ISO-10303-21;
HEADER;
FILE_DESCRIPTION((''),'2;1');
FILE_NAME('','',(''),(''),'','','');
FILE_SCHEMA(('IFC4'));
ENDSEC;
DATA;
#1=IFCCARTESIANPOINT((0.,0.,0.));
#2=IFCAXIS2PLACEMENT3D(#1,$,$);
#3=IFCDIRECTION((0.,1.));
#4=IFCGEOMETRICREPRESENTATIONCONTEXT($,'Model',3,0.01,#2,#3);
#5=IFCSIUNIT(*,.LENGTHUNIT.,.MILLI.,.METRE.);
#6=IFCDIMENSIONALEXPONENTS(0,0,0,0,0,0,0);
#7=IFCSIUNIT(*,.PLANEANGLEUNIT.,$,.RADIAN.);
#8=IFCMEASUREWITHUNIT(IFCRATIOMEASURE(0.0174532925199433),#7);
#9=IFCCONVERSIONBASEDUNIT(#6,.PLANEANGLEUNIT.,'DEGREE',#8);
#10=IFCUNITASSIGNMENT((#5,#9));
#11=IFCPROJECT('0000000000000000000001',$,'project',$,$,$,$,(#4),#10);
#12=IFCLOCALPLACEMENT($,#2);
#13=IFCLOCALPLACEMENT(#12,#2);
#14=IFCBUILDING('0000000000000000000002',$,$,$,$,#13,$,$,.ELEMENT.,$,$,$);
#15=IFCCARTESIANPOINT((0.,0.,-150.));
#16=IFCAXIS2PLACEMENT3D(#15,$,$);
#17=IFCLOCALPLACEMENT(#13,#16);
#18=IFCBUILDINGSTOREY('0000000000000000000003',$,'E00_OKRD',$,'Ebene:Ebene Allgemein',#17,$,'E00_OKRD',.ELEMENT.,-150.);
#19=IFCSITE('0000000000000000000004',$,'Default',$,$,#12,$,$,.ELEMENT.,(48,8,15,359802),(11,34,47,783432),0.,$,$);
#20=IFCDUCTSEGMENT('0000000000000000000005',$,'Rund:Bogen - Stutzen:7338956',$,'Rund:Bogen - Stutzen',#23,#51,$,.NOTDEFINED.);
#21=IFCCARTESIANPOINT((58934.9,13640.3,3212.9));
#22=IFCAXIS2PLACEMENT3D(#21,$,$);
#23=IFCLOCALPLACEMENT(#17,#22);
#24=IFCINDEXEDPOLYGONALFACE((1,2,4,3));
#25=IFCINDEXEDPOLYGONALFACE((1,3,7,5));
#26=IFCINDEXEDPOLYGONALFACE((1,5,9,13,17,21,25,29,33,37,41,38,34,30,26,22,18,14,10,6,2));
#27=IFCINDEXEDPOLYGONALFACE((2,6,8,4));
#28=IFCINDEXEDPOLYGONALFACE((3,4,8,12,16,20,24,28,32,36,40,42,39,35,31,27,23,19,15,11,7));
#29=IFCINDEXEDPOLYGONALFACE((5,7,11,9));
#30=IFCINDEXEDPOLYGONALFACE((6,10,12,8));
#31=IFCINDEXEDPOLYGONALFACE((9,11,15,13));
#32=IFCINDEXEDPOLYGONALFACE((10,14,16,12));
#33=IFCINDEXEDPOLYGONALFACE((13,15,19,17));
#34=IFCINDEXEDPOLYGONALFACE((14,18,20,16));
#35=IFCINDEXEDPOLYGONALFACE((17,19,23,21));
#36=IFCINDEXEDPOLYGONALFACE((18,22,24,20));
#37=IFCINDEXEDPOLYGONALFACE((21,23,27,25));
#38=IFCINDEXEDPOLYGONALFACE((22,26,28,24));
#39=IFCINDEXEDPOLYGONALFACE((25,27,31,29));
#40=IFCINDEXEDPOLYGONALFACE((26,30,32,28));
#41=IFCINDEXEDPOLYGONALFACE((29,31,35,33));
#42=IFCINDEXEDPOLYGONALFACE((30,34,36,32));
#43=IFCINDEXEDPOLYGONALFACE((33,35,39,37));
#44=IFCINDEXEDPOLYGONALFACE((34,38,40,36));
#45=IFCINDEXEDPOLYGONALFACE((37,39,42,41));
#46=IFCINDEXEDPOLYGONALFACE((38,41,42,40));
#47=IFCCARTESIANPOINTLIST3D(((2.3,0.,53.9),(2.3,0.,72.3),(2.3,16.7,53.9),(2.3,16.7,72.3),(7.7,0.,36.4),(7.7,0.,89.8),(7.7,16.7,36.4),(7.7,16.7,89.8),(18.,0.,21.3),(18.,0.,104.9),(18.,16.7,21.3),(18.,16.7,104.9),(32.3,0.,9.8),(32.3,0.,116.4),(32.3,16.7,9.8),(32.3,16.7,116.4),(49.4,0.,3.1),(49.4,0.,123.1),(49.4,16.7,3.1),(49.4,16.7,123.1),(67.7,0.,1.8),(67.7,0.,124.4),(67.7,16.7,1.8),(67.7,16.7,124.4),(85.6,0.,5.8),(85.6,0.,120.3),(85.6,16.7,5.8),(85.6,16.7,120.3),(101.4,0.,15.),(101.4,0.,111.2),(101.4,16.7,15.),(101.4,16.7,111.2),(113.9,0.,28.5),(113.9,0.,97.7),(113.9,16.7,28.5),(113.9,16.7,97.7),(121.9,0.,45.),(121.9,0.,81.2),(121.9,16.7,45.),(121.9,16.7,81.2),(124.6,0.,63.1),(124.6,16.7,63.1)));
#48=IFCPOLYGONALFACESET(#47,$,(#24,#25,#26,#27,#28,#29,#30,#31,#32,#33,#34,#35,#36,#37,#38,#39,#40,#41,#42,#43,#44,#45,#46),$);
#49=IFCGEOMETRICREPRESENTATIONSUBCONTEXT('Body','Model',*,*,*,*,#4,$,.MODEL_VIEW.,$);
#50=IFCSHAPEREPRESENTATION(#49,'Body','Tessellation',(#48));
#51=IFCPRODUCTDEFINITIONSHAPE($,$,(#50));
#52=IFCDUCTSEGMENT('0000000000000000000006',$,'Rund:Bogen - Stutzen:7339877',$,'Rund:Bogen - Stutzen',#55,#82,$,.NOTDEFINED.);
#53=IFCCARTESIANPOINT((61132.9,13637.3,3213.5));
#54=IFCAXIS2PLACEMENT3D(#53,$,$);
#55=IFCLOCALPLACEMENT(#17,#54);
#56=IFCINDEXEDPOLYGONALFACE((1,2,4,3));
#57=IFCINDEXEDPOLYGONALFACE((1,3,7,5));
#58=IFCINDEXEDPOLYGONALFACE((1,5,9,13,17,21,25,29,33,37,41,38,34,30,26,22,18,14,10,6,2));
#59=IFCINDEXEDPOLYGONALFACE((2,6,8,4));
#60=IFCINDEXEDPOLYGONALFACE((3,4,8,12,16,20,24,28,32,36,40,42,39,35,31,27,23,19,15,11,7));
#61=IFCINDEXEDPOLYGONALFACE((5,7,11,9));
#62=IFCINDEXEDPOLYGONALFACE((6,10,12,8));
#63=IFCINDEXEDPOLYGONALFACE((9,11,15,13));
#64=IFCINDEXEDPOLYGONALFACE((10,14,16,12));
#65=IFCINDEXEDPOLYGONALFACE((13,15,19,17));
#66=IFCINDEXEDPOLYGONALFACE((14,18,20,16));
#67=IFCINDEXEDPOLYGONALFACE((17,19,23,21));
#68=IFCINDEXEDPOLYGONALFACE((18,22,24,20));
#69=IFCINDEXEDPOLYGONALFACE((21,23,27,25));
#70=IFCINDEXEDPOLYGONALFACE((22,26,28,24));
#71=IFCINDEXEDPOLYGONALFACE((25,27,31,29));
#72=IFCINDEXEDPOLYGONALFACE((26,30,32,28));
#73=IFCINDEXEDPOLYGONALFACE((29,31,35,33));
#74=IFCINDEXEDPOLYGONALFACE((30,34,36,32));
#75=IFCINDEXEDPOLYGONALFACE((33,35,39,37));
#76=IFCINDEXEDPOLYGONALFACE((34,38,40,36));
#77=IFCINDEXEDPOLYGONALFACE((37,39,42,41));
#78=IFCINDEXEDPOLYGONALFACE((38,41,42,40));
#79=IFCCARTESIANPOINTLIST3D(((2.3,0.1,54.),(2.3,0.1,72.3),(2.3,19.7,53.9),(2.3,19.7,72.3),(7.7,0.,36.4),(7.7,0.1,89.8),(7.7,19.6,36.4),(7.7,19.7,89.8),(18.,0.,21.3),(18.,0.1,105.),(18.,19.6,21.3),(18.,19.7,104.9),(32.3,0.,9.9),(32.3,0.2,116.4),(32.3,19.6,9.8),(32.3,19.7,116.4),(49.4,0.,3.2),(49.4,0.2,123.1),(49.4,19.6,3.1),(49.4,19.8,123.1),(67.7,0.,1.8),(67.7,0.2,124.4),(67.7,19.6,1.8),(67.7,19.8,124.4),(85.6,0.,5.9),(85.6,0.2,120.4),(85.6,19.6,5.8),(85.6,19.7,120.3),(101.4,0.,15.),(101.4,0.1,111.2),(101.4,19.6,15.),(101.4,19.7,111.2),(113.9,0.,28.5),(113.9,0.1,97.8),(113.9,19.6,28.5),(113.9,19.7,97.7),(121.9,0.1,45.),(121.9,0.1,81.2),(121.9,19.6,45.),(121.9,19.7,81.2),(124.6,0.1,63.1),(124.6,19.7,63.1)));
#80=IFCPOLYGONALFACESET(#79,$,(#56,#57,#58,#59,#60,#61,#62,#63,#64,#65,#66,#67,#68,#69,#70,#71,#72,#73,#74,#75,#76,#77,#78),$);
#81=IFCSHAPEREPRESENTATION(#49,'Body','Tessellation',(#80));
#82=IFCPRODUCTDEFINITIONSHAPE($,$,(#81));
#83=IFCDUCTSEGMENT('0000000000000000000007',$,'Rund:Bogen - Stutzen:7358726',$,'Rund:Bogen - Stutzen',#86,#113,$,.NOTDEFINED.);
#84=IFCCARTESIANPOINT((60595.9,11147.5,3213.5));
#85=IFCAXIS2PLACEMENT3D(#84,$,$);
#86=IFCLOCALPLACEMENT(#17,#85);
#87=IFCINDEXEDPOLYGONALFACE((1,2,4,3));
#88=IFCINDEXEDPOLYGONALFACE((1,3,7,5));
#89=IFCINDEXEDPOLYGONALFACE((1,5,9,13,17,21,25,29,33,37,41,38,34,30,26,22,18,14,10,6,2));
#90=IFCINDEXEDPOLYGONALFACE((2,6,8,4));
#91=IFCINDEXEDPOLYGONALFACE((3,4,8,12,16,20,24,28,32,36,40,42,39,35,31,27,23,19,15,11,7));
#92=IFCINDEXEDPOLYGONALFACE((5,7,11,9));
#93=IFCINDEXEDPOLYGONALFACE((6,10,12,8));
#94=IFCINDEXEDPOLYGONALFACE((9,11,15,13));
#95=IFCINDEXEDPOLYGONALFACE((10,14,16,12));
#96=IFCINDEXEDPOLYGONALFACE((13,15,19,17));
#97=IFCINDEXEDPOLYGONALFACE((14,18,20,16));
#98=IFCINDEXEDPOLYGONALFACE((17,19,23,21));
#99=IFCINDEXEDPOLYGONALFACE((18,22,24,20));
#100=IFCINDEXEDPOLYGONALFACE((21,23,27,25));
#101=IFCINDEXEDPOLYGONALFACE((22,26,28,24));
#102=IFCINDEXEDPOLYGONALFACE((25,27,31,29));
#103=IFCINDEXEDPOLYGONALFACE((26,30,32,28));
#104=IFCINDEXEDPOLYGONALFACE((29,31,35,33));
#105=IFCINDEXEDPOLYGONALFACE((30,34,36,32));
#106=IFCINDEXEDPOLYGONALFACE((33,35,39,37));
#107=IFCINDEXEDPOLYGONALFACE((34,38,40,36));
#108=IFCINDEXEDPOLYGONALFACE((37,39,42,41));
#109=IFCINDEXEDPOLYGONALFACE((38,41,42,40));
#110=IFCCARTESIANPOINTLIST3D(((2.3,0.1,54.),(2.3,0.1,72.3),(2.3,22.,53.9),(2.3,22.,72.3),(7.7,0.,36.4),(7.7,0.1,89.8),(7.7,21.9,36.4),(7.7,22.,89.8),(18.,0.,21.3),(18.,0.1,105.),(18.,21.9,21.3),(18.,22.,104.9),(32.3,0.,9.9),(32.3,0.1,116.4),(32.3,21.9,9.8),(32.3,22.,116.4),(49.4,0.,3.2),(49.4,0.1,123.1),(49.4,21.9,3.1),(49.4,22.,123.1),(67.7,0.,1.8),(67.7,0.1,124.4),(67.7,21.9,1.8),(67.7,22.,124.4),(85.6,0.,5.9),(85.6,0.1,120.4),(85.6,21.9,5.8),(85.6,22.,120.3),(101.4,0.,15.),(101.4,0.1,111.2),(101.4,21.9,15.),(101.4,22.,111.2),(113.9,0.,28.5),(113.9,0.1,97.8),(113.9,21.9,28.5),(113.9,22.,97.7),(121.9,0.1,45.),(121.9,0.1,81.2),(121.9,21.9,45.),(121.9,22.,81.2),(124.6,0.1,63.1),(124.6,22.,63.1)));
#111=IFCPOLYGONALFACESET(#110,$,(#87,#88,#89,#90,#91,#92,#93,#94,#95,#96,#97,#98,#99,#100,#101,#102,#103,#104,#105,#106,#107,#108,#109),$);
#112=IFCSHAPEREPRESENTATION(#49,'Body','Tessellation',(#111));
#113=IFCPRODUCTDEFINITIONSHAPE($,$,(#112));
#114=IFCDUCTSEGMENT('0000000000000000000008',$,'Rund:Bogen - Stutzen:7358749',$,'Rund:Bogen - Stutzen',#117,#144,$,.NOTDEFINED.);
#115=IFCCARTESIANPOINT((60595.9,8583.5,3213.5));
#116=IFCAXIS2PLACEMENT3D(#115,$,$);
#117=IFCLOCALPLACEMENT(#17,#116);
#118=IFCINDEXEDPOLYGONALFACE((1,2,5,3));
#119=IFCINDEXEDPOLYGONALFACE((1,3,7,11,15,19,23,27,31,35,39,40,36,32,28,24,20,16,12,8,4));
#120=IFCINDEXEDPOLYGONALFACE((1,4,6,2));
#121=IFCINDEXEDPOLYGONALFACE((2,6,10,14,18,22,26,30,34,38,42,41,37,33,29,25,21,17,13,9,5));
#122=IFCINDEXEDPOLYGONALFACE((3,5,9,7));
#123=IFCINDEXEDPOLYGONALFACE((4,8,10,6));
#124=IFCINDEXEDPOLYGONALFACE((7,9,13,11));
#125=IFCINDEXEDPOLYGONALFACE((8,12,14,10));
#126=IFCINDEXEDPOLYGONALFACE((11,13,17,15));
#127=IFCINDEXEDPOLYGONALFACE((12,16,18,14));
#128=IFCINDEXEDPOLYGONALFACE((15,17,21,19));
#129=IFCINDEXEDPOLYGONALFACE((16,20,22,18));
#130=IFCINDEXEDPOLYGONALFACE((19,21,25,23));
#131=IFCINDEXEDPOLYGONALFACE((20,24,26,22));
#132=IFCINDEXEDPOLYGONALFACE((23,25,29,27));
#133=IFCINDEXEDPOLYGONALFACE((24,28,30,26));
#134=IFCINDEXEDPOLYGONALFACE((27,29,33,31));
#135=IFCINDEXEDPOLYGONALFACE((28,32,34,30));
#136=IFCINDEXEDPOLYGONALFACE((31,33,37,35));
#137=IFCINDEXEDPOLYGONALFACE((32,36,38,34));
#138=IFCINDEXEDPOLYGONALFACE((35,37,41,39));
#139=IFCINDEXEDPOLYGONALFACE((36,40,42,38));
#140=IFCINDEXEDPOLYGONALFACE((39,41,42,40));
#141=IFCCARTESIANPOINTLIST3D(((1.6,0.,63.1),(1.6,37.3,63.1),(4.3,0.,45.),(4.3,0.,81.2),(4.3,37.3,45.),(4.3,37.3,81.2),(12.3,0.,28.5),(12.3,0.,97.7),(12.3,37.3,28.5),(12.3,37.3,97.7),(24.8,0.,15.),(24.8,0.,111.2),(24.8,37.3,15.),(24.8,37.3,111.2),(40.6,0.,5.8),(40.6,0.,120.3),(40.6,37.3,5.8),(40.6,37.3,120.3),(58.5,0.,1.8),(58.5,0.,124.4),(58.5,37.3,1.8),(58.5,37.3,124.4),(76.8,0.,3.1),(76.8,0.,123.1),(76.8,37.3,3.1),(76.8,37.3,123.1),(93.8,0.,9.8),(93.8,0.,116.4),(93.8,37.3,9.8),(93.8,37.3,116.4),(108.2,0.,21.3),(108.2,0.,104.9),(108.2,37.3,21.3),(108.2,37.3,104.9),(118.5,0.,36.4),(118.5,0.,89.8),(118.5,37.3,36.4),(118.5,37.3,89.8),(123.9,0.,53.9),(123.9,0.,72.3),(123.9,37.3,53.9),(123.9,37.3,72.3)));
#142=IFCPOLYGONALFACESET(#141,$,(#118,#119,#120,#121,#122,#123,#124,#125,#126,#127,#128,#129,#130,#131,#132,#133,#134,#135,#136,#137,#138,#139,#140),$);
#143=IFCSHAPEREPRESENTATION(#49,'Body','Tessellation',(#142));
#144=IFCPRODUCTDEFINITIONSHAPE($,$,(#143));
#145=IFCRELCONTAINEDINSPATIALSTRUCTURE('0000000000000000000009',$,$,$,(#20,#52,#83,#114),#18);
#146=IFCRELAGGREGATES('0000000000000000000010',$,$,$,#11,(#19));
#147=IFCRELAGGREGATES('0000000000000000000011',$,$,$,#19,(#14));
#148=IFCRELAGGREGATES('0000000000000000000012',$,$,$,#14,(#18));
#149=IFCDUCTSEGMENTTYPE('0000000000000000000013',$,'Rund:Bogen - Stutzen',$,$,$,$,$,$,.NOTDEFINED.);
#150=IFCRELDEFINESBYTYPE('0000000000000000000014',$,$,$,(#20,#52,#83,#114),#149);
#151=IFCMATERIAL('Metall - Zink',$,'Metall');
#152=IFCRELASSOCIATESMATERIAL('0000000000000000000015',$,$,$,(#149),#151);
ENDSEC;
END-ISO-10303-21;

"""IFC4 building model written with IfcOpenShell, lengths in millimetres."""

from ifc_helpers import new_model, entity, si_unit, converted_unit, direction, frame, frame_2d, origin, origin_2d_with_axis, place, context, subcontext, project, spatial, circle, extrude, material, type_object, element, save


model = new_model("IFC4")

# Units and contexts
model_context = context("Model", 3, precision=0.01, world=origin(), true_north=direction((0.0, 1.0)))
body_context = subcontext(model_context, "Body", "Model", "MODEL_VIEW")
ifc_project = project(units=[si_unit("LENGTHUNIT", "METRE", prefix="MILLI"), converted_unit("PLANEANGLEUNIT", "DEGREE", entity("IfcRatioMeasure", 0.0174532925199433), si_unit("PLANEANGLEUNIT", "RADIAN"), dimensions=[0, 0, 0, 0, 0, 0, 0])], contexts=[model_context])

# Site, building, storey
site_placement = place(None, origin())
site = spatial("IfcSite", under=ifc_project, at=site_placement, Name="Default", CompositionType="ELEMENT", RefLatitude=(48, 8, 15, 359802), RefLongitude=(11, 34, 47, 783432), RefElevation=0.0)
building_placement = place(site_placement, origin())
building = spatial("IfcBuilding", under=site, at=building_placement, CompositionType="ELEMENT")
storey_placement = place(building_placement, frame((0.0, 0.0, -150.0)))
storey = spatial("IfcBuildingStorey", under=building, at=storey_placement, Name="E00_OKRD", ObjectType="Ebene:Ebene Allgemein", LongName="E00_OKRD", CompositionType="ELEMENT", Elevation=-150.0)

# Shared definitions
ifc_material_1 = material(Name="Metall - Zink", Category="Metall")

# Duct segments
duct_segment_type_1 = type_object("IfcDuctSegmentType", Name="Rund:Bogen - Stutzen", PredefinedType="NOTDEFINED", material=ifc_material_1)
duct_segment_1_placement = place(storey_placement, frame((58934.9, 13640.3, 3212.9)))
element("IfcDuctSegment", 1, at=duct_segment_1_placement, inside=storey, type_object=duct_segment_type_1, Name="Rund:Bogen - Stutzen:7338956", ObjectType="Rund:Bogen - Stutzen", PredefinedType="NOTDEFINED", context=body_context, shape_type="SweptSolid", body=[
    extrude(circle(Radius=61.5, at=frame_2d((0.0, 0.0), x_axis=(1.0, 0.0))), frame((63.1, 0.0, 63.1), z_axis=(0.0, 1.0, 0.0), x_axis=(1.0, 0.0, 0.0)), (0.0, 0.0, 1.0), 16.7),
])
duct_segment_2_placement = place(storey_placement, frame((61132.9, 13637.3, 3213.5)))
element("IfcDuctSegment", 2, at=duct_segment_2_placement, inside=storey, type_object=duct_segment_type_1, Name="Rund:Bogen - Stutzen:7339877", ObjectType="Rund:Bogen - Stutzen", PredefinedType="NOTDEFINED", context=body_context, shape_type="SweptSolid", body=[
    extrude(circle(Radius=61.5, at=frame_2d((0.0, 0.0), x_axis=(1.0, 0.0))), frame((63.1, 19.7, 63.1), z_axis=(0.0, -0.999999, 0.001314), x_axis=(1.0, 0.0, 0.0)), (0.0, 0.0, 1.0), 19.6),
])
duct_segment_3_placement = place(storey_placement, frame((60595.9, 11147.5, 3213.5)))
element("IfcDuctSegment", 3, at=duct_segment_3_placement, inside=storey, type_object=duct_segment_type_1, Name="Rund:Bogen - Stutzen:7358726", ObjectType="Rund:Bogen - Stutzen", PredefinedType="NOTDEFINED", context=body_context, shape_type="SweptSolid", body=[
    extrude(circle(Radius=61.5, at=frame_2d((0.0, 0.0), x_axis=(1.0, 0.0))), frame((63.1, 0.1, 63.1), z_axis=(0.0, 0.999999, -0.001176), x_axis=(1.0, 0.0, 0.0)), (0.0, 0.0, 1.0), 21.9),
])
duct_segment_4_placement = place(storey_placement, frame((60595.9, 8583.5, 3213.5)))
element("IfcDuctSegment", 4, at=duct_segment_4_placement, inside=storey, type_object=duct_segment_type_1, Name="Rund:Bogen - Stutzen:7358749", ObjectType="Rund:Bogen - Stutzen", PredefinedType="NOTDEFINED", context=body_context, shape_type="SweptSolid", body=[
    extrude(circle(Radius=61.5, at=origin_2d_with_axis()), frame((63.1, 0.0, 63.1), z_axis=(0.0, 1.0, 0.0), x_axis=(-1.0, 0.0, 0.0)), (0.0, 0.0, 1.0), 37.3),
])

save(model, "model.ifc")
